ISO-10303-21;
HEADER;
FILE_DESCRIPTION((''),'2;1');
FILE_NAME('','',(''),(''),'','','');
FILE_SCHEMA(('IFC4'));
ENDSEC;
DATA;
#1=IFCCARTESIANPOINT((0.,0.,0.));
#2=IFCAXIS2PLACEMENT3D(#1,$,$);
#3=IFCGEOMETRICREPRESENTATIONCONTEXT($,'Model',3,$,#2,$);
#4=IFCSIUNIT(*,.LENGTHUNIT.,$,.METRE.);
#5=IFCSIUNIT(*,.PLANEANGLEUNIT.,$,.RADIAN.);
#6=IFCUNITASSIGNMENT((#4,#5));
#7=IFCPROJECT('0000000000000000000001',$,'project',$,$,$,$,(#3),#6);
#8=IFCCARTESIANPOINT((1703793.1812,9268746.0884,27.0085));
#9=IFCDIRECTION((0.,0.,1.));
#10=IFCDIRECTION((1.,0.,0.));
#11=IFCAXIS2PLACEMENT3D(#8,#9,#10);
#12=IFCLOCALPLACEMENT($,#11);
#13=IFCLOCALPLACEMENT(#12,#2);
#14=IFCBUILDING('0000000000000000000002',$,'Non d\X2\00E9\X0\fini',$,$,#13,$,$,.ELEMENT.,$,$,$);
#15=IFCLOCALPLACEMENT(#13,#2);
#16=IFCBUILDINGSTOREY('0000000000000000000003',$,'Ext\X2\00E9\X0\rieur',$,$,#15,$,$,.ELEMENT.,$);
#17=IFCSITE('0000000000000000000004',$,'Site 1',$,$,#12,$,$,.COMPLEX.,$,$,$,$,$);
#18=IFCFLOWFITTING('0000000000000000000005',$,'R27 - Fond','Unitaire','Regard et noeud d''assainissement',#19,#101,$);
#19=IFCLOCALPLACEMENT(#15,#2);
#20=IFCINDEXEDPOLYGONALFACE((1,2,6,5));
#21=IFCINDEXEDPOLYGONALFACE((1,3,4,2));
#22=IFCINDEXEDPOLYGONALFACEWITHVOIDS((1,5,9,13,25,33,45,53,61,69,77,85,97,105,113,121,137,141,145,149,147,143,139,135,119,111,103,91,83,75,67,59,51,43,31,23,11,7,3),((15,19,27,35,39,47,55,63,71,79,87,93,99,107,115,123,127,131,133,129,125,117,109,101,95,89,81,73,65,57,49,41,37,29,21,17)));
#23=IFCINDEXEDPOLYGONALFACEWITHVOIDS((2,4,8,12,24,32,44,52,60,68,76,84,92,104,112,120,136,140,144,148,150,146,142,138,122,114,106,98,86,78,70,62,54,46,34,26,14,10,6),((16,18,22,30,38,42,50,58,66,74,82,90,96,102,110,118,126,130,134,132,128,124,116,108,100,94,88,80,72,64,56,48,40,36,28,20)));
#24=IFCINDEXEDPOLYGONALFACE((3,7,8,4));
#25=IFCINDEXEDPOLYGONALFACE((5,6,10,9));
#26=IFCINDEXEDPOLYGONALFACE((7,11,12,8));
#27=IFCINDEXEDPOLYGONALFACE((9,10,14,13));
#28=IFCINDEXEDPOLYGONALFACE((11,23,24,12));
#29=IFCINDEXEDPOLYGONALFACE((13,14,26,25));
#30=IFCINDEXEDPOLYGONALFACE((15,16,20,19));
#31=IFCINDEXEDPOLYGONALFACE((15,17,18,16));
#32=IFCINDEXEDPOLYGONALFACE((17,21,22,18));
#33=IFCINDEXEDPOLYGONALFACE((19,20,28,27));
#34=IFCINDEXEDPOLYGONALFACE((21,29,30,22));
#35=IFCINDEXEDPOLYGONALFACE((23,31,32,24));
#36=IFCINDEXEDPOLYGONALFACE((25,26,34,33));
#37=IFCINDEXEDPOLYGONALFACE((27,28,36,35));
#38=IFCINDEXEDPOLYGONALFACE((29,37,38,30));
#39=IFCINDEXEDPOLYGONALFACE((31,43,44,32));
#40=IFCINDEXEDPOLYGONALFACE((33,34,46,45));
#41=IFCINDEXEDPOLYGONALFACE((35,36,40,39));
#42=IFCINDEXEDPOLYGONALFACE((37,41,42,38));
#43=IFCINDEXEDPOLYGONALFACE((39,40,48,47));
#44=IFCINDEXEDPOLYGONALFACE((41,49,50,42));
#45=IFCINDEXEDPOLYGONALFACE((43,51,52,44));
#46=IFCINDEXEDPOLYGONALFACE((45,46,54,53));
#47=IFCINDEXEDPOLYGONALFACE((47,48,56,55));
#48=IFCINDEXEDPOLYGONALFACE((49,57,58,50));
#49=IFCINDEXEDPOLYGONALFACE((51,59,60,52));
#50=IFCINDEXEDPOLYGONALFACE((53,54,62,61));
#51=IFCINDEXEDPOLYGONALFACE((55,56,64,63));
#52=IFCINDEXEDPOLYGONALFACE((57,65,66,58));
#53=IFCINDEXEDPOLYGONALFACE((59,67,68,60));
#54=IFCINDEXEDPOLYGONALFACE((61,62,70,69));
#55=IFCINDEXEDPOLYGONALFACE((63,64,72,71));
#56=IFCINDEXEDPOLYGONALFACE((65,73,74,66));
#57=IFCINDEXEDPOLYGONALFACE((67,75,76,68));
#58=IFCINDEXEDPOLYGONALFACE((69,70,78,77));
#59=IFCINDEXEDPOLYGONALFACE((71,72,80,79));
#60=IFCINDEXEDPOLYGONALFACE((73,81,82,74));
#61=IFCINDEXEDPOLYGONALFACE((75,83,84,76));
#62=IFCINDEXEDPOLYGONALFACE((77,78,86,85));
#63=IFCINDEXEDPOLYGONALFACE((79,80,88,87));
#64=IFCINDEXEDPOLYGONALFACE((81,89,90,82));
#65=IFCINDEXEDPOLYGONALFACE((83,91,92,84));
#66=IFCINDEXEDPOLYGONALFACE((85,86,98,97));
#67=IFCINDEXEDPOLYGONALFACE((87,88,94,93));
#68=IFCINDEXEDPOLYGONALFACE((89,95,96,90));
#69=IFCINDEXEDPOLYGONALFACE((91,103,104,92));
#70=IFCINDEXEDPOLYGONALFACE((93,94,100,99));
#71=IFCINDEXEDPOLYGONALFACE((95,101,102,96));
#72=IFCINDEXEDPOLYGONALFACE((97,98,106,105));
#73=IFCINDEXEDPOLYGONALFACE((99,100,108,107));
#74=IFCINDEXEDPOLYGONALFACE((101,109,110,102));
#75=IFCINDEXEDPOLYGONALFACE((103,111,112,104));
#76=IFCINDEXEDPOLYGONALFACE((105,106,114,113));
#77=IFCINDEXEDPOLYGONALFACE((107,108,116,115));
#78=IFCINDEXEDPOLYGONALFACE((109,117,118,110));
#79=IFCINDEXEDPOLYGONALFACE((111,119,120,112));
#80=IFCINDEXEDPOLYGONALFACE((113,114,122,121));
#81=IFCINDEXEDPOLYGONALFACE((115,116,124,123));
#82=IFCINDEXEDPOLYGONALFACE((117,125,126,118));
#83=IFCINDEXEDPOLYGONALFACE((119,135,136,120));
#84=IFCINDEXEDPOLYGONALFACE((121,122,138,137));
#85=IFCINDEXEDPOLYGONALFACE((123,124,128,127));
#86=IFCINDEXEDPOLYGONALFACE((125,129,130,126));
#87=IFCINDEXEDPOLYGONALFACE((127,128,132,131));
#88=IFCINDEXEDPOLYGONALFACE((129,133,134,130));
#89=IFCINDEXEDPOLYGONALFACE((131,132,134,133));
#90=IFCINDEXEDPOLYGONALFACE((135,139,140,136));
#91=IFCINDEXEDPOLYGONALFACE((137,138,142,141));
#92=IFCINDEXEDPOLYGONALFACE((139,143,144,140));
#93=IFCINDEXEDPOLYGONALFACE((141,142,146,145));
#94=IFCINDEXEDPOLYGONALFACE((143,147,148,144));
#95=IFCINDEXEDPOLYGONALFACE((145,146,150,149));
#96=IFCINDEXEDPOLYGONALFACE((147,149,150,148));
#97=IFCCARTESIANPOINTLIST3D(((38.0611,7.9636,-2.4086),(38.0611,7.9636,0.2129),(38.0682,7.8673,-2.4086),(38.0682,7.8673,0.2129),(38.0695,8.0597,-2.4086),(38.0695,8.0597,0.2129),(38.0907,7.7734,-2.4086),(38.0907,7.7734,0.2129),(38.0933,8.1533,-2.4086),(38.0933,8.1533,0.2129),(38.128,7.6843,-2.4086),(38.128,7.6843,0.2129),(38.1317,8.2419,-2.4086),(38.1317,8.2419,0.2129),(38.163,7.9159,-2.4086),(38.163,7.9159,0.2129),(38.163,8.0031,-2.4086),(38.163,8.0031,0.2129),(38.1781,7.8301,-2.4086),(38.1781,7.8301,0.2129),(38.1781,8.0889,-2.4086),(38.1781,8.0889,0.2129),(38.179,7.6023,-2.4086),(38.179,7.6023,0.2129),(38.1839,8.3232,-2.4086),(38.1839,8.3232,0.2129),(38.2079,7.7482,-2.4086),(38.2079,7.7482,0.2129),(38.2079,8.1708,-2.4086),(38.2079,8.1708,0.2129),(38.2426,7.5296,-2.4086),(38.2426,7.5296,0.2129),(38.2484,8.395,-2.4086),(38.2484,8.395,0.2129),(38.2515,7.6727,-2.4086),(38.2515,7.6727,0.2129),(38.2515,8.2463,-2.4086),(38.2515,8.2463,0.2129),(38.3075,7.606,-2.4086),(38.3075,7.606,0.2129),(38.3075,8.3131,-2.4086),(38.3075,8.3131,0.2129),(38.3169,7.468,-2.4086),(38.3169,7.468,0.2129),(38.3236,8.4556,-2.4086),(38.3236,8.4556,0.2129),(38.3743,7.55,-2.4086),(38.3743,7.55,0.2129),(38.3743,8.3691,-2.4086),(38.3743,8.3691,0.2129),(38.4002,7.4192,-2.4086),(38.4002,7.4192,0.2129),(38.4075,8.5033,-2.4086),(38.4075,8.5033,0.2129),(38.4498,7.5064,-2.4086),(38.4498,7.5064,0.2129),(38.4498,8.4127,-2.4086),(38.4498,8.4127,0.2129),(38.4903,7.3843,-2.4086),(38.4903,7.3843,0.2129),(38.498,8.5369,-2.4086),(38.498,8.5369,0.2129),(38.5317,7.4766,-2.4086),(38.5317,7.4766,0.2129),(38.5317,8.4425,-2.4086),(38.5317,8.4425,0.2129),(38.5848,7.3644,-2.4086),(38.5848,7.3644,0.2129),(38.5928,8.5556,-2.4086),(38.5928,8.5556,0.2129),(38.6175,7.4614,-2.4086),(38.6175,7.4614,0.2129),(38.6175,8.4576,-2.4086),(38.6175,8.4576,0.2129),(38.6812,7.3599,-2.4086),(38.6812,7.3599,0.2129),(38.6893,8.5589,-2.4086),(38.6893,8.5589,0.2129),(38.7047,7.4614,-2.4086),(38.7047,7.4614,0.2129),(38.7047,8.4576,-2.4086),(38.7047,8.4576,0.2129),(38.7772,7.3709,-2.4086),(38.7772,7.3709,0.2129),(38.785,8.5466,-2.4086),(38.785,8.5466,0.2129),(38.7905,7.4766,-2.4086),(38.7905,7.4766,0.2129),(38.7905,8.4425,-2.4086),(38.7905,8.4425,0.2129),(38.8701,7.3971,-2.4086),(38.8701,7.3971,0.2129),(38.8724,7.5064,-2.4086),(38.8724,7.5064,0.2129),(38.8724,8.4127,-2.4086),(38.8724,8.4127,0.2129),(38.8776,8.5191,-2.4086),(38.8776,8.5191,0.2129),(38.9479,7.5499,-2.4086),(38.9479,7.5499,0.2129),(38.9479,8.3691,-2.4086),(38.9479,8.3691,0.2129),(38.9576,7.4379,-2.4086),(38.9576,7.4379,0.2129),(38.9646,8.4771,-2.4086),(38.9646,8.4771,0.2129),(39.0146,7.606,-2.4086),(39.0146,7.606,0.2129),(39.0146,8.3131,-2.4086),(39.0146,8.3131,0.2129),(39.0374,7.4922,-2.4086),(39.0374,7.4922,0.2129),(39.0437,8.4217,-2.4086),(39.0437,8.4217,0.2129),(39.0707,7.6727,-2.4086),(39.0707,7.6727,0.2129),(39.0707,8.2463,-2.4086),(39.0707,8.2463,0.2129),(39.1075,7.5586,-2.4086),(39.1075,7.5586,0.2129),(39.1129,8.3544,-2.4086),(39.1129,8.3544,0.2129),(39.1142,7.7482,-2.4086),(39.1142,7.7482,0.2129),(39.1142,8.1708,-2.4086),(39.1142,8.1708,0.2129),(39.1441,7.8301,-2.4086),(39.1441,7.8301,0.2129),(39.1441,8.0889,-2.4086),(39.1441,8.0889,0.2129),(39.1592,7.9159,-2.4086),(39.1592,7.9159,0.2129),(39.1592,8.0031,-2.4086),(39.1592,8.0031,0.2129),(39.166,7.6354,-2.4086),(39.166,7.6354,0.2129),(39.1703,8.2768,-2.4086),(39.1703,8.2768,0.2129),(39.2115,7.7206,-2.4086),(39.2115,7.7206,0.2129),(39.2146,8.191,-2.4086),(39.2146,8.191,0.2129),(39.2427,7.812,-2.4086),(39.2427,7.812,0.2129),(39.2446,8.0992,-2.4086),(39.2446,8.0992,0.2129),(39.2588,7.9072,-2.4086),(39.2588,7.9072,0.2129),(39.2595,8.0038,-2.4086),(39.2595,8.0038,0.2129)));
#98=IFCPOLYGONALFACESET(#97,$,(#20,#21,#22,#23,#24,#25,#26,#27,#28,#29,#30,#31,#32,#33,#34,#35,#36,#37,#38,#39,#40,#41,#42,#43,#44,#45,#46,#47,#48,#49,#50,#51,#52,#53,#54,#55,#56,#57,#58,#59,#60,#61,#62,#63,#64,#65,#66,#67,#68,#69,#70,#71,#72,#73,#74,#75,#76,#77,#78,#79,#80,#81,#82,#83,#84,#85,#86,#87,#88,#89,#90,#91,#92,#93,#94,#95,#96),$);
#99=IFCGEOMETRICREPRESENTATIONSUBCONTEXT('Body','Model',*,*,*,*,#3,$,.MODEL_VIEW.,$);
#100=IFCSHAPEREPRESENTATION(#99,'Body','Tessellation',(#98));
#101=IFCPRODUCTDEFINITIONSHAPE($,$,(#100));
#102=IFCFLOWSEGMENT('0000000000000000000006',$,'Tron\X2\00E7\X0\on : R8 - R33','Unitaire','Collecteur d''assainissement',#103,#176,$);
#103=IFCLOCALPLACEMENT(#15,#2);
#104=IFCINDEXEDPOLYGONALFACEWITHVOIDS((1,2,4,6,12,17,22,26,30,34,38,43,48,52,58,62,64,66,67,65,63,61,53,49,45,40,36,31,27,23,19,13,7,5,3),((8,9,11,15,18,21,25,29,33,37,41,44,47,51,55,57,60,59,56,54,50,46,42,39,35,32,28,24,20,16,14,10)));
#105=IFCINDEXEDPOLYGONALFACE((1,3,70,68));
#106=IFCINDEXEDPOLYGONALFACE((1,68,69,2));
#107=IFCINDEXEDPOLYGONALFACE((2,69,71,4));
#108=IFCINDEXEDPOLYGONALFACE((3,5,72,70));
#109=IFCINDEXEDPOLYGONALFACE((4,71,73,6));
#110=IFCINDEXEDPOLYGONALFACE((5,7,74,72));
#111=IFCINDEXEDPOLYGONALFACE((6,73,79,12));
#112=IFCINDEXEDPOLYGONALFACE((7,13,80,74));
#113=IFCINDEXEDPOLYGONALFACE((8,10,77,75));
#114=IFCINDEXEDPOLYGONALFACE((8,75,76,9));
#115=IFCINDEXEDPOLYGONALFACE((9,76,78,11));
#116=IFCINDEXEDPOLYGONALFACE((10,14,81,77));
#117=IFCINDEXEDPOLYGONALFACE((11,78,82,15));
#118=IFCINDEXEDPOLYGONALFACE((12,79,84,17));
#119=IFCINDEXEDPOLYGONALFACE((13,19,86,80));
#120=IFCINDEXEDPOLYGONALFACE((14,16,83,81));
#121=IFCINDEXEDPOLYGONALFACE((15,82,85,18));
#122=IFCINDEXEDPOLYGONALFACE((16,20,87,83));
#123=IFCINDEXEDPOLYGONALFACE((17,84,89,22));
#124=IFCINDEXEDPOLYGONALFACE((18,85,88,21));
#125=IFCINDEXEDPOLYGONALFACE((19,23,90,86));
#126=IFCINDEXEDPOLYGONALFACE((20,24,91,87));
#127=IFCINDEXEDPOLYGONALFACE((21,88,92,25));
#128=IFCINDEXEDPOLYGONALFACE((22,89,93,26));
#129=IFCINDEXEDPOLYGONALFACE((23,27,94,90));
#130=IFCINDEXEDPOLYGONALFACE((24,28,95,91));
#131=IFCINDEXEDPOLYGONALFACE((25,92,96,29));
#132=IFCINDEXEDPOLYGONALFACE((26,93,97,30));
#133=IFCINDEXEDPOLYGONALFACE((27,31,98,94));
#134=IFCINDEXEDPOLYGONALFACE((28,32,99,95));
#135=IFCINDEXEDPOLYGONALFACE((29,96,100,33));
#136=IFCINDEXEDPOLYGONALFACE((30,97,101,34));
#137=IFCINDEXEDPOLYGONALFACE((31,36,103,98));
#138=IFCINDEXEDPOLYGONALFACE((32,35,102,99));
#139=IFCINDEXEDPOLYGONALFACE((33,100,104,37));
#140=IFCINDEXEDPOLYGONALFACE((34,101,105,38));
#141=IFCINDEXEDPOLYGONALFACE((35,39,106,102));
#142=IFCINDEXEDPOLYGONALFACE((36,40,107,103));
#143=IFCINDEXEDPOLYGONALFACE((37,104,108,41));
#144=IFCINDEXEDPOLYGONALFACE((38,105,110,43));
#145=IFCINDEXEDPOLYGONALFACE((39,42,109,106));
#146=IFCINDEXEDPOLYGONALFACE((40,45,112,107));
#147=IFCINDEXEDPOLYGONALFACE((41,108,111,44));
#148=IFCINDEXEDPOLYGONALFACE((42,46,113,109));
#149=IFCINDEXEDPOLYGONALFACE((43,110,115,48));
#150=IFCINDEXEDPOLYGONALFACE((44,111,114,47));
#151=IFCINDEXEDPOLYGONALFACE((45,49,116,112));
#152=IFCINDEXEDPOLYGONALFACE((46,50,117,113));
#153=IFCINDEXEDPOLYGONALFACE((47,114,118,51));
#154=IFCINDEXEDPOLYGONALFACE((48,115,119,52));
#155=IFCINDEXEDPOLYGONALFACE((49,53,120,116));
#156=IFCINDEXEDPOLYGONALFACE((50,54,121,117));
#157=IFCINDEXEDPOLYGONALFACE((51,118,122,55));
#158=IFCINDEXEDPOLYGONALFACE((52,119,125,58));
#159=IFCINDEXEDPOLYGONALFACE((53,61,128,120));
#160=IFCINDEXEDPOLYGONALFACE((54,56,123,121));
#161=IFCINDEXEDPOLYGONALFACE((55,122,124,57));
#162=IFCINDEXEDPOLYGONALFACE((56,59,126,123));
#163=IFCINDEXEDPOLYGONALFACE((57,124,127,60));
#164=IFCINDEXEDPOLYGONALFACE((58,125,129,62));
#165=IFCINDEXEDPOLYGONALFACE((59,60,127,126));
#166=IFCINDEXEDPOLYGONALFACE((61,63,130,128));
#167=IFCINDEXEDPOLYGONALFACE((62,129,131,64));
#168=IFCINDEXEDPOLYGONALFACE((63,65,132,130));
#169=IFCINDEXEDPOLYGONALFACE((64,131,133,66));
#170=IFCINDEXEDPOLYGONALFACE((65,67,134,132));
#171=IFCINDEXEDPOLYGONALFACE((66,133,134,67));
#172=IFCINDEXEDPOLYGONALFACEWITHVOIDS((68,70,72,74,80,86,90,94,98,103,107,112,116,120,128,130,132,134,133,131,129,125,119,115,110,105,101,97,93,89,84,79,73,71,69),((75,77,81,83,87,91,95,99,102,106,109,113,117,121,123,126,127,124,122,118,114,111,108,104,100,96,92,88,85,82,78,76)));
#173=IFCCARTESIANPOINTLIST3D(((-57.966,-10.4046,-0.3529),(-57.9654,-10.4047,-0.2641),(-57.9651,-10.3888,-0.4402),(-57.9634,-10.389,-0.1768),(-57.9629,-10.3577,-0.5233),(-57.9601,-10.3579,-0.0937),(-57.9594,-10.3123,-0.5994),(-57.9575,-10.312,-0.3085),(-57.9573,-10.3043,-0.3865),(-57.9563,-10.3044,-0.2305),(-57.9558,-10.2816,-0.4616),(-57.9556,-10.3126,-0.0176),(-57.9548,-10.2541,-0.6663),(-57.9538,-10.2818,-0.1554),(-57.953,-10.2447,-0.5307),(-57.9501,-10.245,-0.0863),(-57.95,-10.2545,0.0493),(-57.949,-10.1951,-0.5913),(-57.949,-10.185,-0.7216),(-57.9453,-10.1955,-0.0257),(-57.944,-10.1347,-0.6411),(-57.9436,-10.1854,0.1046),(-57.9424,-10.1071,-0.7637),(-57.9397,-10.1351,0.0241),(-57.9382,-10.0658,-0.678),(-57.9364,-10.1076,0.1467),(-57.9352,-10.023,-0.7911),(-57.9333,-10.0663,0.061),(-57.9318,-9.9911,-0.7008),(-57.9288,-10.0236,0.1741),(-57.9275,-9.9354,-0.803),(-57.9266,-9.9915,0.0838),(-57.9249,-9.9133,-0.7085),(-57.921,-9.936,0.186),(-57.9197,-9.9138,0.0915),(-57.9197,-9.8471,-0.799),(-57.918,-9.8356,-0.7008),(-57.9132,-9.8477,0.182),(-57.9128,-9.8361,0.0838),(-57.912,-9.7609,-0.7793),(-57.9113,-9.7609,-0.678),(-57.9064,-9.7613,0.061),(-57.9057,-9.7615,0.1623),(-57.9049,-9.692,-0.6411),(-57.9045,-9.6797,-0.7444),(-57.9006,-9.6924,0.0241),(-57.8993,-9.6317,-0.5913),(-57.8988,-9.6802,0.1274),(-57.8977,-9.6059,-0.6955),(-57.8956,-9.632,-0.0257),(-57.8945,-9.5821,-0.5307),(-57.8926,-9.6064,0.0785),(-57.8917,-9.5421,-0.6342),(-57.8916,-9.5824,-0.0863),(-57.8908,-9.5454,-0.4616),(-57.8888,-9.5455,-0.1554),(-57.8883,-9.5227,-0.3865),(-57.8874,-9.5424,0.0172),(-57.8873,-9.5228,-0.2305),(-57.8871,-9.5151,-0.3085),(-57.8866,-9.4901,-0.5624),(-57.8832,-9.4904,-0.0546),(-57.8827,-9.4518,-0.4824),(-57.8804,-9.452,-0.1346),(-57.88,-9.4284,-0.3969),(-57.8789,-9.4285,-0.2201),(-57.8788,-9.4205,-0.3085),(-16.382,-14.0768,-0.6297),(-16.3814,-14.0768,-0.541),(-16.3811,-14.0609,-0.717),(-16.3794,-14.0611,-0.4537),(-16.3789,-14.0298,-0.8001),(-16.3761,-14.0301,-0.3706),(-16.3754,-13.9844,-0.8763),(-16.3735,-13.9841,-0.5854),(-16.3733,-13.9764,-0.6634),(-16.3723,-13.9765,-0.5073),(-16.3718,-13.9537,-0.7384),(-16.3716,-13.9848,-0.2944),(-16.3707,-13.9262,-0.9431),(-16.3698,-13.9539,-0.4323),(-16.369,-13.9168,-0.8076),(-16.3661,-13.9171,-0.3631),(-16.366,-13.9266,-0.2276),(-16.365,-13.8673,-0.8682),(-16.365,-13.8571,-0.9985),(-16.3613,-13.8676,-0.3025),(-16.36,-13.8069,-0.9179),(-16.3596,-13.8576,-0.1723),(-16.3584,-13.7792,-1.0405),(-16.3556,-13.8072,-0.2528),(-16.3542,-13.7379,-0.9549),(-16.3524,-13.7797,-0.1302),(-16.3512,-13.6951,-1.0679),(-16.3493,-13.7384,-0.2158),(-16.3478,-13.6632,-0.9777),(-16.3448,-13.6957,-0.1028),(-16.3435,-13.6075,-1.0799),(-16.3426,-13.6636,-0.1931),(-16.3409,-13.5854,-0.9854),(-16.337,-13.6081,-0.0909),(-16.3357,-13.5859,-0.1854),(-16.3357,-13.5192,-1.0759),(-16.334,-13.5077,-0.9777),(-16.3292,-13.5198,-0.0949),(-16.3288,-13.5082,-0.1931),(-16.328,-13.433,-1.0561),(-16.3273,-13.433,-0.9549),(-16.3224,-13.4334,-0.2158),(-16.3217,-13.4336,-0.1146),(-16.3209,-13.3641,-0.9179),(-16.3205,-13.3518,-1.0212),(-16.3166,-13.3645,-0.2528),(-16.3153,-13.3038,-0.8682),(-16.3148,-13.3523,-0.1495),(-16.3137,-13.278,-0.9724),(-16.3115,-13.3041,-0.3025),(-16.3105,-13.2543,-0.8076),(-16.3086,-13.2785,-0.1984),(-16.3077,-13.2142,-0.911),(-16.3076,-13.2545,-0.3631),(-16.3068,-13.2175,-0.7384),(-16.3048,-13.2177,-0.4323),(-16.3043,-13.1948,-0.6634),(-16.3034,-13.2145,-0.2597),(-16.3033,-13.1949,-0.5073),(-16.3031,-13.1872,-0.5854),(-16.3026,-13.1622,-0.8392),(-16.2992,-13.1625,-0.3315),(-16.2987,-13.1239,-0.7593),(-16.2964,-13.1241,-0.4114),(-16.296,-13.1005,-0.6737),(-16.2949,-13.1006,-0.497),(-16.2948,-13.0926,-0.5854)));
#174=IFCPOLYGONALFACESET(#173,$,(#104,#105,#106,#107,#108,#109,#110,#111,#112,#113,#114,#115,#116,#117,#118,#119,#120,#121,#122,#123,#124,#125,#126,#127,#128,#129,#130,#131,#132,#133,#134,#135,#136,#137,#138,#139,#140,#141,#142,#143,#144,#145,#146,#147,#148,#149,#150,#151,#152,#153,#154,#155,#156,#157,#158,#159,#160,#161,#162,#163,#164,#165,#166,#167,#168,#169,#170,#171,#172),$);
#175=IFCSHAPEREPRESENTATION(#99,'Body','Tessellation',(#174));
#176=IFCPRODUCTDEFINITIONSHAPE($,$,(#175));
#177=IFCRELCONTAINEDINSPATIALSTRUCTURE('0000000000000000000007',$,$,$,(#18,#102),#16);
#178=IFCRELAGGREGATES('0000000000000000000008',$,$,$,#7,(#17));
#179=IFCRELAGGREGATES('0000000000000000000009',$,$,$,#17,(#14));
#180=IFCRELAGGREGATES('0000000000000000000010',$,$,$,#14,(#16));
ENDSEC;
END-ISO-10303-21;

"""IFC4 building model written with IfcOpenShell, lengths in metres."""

from ifc_helpers import new_model, si_unit, frame, origin, origin_2d, place, context, subcontext, project, spatial, hollow_circle, extrude, element, save


model = new_model("IFC4")

# Units and contexts
model_context = context("Model", 3, world=origin())
body_context = subcontext(model_context, "Body", "Model", "MODEL_VIEW")
ifc_project = project(units=[si_unit("LENGTHUNIT", "METRE"), si_unit("PLANEANGLEUNIT", "RADIAN")], contexts=[model_context])

# Site, building, storey
site_placement = place(None, frame((1703793.1812, 9268746.0884, 27.0085), z_axis=(0.0, 0.0, 1.0), x_axis=(1.0, 0.0, 0.0)))
site = spatial("IfcSite", under=ifc_project, at=site_placement, Name="Site 1", CompositionType="COMPLEX")
building_placement = place(site_placement, origin())
building = spatial("IfcBuilding", under=site, at=building_placement, Name="Non défini", CompositionType="ELEMENT")
storey_placement = place(building_placement, origin())
storey = spatial("IfcBuildingStorey", under=building, at=storey_placement, Name="Extérieur", CompositionType="ELEMENT")

# Flow fitting
flow_fitting_1_placement = place(storey_placement, origin())
element("IfcFlowFitting", 1, at=flow_fitting_1_placement, inside=storey, Name="R27 - Fond", Description="Unitaire", ObjectType="Regard et noeud d'assainissement", context=body_context, shape_type="SweptSolid", body=[
    extrude(hollow_circle(Radius=0.6, WallThickness=0.1, at=origin_2d()), frame((38.6611, 7.9595, -2.4086), z_axis=(0.0, 0.0, 1.0), x_axis=(0.996194, -0.087159, 0.0)), (0.0, 0.0, 1.0), 2.6215),
])

# Flow segment
flow_segment_1_placement = place(storey_placement, origin())
element("IfcFlowSegment", 2, at=flow_segment_1_placement, inside=storey, Name="Tronçon : R8 - R33", Description="Unitaire", ObjectType="Collecteur d'assainissement", context=body_context, shape_type="SweptSolid", body=[
    extrude(hollow_circle(Radius=0.495, WallThickness=0.095, at=origin_2d()), frame((-57.9223, -9.9136, -0.3085), z_axis=(0.996102, -0.087962, -0.006632), x_axis=(0.087964, 0.996124, 0.0)), (0.0, 0.0, 1.0), 41.7467),
])

save(model, "model.ifc")
